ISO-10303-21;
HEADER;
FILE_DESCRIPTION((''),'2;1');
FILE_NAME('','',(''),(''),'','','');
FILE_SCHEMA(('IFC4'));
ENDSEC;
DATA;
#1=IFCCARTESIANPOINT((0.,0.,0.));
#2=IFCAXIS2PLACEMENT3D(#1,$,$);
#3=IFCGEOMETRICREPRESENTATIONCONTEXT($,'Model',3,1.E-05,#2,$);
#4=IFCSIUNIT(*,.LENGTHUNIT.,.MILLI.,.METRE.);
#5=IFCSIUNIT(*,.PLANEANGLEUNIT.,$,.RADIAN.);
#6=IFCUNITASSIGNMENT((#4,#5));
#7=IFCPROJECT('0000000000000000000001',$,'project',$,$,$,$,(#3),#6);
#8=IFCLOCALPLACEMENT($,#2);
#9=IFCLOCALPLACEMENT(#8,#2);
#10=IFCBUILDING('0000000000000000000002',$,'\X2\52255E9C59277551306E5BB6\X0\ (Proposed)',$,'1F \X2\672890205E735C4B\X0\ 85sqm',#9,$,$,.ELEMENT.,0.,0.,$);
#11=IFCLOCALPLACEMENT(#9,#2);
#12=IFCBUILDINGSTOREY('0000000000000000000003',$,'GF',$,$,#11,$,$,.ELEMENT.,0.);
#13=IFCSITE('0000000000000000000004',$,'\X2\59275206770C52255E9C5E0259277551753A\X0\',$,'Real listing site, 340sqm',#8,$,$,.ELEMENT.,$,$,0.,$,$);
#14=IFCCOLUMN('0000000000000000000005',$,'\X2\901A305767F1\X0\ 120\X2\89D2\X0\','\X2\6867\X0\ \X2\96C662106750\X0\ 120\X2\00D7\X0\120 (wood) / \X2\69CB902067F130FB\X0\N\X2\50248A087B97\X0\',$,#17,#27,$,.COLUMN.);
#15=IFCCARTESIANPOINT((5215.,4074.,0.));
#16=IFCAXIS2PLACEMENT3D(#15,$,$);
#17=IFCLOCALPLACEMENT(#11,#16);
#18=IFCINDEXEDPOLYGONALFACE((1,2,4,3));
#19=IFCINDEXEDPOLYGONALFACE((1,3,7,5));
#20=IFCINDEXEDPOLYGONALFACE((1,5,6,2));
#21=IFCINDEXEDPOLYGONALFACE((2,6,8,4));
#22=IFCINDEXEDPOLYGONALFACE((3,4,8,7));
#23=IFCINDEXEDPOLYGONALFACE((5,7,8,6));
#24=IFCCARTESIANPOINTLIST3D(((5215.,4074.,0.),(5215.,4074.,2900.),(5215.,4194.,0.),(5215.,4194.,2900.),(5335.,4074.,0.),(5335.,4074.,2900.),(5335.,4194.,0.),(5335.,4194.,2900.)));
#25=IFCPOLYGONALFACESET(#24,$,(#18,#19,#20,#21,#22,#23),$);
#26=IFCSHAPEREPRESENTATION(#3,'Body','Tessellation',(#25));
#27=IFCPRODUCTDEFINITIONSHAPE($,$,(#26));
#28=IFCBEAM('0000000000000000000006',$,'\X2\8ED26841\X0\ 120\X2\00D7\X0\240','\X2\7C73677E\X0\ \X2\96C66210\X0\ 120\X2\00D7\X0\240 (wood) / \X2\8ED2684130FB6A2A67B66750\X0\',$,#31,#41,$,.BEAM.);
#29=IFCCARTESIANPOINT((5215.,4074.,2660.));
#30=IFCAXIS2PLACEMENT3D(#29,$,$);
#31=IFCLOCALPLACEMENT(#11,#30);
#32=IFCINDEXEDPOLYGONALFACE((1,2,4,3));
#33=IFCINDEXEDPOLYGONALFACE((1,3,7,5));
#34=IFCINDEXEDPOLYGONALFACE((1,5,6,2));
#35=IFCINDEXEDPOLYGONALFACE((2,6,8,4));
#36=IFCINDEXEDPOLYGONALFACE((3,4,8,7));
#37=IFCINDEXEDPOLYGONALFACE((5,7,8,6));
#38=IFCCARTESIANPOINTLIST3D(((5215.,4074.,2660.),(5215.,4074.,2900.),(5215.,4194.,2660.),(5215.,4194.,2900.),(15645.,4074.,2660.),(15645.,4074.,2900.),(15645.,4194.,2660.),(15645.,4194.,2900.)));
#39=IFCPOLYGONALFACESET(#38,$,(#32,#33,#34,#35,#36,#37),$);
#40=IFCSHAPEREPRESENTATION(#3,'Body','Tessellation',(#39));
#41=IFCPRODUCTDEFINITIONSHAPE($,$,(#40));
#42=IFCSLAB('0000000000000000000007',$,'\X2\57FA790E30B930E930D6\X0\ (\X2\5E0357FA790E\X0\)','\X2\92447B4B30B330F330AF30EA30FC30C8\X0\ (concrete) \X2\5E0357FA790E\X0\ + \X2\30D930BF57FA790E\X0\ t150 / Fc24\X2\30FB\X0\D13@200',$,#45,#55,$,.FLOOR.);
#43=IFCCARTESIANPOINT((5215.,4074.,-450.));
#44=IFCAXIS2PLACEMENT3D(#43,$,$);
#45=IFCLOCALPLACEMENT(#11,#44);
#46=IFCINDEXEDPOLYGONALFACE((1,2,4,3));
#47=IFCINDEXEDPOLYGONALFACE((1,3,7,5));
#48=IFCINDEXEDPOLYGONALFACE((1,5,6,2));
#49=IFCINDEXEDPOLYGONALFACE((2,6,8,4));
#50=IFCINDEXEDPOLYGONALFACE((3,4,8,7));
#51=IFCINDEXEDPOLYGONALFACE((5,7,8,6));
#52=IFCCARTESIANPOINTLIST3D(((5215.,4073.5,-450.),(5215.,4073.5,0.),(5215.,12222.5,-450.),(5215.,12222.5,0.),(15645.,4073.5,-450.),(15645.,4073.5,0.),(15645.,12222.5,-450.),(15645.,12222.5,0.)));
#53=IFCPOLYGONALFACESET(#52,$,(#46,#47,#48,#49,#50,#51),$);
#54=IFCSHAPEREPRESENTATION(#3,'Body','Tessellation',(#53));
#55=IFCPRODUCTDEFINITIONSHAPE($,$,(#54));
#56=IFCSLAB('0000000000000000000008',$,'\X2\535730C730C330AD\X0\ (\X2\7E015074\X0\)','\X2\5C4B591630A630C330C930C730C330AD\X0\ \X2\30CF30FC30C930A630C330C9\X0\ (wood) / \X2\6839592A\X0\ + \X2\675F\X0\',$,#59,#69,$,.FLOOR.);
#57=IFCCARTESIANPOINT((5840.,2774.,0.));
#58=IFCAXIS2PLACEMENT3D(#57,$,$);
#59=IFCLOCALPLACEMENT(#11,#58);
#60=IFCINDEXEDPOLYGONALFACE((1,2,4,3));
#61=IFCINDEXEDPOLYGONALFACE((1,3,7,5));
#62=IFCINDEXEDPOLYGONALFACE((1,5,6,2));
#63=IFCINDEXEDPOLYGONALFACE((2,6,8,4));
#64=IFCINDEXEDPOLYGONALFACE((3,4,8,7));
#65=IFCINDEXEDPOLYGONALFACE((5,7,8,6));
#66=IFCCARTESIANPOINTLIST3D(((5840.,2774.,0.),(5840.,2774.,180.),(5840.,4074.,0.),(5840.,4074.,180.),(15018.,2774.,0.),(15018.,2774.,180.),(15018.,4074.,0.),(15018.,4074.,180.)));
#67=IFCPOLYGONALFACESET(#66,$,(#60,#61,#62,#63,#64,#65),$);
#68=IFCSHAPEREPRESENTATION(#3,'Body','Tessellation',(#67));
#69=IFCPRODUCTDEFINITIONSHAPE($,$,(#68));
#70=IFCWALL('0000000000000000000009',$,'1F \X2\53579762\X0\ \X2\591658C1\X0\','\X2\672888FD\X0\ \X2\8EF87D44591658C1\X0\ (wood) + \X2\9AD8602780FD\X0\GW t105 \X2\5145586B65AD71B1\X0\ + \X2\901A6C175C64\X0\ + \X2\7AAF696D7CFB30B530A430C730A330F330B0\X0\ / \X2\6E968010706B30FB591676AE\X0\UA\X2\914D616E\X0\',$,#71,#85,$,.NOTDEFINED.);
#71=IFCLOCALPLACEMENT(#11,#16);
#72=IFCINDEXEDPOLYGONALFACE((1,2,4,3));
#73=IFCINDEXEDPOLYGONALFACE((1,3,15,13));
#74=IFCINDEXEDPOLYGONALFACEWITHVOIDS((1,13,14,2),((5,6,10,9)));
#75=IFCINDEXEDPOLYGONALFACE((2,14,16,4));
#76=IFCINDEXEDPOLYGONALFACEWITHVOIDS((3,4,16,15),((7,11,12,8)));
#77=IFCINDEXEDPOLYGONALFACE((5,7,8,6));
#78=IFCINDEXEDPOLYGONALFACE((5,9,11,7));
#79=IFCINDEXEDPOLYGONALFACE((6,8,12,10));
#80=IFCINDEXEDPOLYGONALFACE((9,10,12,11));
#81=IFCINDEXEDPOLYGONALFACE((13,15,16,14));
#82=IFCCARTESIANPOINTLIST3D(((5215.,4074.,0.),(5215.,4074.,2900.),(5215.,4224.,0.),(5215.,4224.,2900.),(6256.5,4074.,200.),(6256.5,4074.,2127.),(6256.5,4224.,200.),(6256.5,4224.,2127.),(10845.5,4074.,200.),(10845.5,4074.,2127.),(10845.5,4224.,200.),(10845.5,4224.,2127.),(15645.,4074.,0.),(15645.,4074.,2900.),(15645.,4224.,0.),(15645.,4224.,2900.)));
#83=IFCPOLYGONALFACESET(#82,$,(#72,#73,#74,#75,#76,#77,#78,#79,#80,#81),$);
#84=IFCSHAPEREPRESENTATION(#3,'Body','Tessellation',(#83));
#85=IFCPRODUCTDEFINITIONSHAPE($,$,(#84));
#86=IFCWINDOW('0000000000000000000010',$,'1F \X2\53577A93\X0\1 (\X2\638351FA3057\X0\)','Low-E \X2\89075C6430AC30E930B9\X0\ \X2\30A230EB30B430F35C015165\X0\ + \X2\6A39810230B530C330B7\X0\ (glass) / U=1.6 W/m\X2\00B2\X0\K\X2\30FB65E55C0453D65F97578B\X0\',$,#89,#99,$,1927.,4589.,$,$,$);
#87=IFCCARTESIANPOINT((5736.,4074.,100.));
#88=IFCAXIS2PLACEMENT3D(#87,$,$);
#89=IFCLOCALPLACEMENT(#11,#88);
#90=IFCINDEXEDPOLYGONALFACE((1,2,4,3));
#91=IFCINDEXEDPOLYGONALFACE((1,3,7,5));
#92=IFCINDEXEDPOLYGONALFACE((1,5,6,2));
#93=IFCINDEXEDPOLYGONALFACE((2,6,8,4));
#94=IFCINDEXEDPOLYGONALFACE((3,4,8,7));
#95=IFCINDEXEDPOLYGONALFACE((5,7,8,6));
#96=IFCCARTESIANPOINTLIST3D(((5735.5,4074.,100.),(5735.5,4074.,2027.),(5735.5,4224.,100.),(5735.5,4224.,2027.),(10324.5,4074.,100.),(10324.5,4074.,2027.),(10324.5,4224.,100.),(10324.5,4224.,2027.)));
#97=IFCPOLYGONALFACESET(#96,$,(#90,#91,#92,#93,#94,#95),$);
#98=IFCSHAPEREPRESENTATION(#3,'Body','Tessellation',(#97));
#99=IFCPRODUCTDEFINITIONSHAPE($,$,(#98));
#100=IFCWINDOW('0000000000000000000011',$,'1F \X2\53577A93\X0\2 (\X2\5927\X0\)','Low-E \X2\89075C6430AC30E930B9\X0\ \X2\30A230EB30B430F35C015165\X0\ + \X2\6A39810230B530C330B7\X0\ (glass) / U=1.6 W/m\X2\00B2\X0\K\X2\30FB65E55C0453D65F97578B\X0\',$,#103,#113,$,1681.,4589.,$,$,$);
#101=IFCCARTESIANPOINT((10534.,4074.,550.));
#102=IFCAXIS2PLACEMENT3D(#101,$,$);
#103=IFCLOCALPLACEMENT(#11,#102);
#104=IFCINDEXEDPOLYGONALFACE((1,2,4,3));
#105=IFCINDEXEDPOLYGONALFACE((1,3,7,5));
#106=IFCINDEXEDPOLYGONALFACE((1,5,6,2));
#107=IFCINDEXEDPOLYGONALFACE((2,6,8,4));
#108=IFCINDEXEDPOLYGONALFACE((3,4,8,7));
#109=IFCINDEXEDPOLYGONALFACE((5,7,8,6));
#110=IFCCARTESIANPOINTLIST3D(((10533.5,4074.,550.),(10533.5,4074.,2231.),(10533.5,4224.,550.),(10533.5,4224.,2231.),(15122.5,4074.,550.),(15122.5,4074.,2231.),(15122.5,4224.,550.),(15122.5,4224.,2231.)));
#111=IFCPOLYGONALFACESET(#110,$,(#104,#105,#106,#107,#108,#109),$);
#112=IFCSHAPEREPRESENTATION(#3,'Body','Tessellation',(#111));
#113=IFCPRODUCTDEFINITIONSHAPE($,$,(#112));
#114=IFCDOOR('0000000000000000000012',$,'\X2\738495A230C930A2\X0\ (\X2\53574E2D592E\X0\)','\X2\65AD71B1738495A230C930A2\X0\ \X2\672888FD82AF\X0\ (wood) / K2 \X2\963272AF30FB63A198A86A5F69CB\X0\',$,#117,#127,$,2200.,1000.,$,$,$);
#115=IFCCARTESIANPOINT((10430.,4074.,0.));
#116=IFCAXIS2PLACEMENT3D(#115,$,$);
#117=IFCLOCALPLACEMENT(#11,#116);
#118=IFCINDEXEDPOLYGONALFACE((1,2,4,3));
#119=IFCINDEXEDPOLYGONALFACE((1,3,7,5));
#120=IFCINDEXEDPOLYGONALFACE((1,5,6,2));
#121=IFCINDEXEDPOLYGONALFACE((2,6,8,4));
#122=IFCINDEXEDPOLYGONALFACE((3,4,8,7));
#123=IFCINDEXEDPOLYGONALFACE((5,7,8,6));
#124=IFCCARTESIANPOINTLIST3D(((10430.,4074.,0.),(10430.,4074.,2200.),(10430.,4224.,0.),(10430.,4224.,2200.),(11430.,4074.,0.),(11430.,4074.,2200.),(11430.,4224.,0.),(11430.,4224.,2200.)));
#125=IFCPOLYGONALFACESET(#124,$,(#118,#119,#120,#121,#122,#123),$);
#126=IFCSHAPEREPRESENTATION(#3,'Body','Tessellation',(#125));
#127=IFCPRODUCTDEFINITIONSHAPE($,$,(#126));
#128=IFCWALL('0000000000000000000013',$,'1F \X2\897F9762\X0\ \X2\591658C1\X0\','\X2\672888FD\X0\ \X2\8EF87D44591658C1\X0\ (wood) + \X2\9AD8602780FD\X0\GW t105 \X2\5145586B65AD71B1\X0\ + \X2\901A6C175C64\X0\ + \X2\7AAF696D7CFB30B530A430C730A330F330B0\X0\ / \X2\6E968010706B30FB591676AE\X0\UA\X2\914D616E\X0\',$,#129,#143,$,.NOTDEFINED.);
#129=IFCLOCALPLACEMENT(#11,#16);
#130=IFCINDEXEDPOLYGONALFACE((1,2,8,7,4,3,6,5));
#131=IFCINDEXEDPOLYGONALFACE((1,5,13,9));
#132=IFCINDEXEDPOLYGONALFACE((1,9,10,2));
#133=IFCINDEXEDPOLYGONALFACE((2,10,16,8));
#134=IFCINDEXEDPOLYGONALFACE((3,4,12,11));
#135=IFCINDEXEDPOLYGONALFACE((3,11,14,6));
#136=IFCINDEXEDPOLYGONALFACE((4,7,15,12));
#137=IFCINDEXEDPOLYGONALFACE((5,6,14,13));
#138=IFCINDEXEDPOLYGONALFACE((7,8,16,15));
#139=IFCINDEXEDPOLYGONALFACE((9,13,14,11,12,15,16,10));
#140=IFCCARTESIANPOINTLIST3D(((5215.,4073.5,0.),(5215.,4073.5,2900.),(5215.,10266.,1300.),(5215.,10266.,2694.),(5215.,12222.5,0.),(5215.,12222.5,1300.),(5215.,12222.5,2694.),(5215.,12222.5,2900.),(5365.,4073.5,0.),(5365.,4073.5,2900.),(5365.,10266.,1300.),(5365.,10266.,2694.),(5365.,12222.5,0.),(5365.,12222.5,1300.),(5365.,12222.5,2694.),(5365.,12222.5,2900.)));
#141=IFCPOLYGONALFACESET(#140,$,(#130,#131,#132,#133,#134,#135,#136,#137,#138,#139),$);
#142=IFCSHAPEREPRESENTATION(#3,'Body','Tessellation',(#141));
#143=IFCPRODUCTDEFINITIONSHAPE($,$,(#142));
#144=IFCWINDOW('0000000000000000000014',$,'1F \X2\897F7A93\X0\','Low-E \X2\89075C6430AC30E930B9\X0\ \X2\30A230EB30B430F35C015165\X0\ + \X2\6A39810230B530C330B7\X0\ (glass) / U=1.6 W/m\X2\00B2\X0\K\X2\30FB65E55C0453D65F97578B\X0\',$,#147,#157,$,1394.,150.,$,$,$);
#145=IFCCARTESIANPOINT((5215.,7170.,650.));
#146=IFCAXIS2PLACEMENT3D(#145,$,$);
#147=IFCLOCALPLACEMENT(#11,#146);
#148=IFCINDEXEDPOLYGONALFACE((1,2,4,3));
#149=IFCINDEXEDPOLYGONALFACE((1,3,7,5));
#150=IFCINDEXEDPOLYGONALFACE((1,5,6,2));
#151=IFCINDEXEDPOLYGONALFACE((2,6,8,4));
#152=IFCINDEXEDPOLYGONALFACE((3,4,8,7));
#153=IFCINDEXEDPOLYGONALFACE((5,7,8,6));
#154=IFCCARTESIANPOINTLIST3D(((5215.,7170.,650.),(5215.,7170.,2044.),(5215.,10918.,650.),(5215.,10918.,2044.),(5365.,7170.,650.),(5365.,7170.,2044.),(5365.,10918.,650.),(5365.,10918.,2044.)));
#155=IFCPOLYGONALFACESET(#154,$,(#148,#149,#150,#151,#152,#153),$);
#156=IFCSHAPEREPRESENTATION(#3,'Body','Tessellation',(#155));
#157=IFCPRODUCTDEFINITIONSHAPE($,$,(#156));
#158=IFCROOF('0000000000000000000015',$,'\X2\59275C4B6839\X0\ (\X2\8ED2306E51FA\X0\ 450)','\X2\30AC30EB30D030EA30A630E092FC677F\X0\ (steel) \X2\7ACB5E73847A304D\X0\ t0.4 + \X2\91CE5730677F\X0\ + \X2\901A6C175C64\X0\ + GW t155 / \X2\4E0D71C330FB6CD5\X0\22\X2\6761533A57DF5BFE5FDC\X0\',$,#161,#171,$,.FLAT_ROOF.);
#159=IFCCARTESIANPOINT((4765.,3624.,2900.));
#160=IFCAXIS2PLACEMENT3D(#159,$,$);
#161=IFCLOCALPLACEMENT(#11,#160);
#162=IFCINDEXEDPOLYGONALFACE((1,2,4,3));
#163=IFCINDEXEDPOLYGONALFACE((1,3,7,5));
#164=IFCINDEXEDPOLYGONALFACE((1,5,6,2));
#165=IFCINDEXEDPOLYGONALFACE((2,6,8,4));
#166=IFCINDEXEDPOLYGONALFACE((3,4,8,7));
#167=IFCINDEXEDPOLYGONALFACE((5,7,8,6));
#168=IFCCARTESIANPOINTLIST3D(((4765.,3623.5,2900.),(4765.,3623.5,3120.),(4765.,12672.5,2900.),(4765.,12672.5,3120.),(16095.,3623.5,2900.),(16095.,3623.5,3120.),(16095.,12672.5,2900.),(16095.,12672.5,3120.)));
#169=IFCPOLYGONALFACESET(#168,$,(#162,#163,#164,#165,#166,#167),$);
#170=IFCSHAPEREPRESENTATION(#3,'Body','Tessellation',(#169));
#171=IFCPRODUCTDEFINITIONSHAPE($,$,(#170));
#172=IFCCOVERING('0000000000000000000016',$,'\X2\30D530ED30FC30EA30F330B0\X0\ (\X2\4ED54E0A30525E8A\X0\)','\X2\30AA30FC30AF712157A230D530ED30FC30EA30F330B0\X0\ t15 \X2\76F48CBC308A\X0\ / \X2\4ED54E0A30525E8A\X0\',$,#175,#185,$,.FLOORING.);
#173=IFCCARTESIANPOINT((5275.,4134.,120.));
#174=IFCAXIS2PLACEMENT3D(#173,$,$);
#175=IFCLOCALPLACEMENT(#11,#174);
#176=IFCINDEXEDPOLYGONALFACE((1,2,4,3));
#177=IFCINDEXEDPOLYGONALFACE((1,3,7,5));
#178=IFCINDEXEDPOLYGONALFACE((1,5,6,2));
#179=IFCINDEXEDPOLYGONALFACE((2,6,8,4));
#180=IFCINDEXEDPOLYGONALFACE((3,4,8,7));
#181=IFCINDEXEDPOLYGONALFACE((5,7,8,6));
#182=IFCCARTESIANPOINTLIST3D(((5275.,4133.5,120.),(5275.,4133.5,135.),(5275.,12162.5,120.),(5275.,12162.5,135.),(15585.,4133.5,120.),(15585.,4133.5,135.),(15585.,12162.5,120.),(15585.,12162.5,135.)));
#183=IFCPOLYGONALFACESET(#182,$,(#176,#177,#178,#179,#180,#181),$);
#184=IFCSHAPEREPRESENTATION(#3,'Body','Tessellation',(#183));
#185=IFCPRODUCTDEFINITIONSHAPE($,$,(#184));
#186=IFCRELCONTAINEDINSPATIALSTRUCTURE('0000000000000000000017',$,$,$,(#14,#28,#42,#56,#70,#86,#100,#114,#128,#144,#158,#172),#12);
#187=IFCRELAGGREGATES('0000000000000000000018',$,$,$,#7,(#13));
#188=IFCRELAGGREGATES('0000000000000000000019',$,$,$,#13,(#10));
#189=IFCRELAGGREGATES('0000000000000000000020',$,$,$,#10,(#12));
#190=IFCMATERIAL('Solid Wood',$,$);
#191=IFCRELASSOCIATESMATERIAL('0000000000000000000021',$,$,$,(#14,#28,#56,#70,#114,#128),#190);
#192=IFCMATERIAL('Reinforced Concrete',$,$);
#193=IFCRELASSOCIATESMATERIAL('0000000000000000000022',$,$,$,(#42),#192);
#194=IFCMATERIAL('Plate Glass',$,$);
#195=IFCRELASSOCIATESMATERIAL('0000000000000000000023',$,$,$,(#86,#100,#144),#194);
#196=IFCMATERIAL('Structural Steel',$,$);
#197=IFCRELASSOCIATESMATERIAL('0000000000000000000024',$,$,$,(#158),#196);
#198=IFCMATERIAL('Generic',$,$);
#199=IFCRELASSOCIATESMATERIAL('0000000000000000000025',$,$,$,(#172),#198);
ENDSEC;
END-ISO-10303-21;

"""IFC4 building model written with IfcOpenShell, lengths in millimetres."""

from ifc_helpers import new_model, si_unit, frame, frame_2d, origin, place, context, project, spatial, rectangle, extrude, material, element, fill, save


model = new_model("IFC4")

# Units and contexts
model_context = context("Model", 3, precision=1e-05, world=origin())
ifc_project = project(units=[si_unit("LENGTHUNIT", "METRE", prefix="MILLI"), si_unit("PLANEANGLEUNIT", "RADIAN")], contexts=[model_context])

# Site, building, storey
site_placement = place(None, origin())
site = spatial("IfcSite", under=ifc_project, at=site_placement, Name="大分県別府市大畑町", ObjectType="Real listing site, 340sqm", CompositionType="ELEMENT", RefElevation=0.0)
building_placement = place(site_placement, origin())
building = spatial("IfcBuilding", under=site, at=building_placement, Name="別府大畑の家 (Proposed)", ObjectType="1F 木造平屋 85sqm", CompositionType="ELEMENT", ElevationOfRefHeight=0.0, ElevationOfTerrain=0.0)
storey_placement = place(building_placement, origin())
storey = spatial("IfcBuildingStorey", under=building, at=storey_placement, Name="GF", CompositionType="ELEMENT", Elevation=0.0)

# Column
ifc_material_1 = material(Name="Solid Wood")
column_1_placement = place(storey_placement, frame((5215.0, 4074.0, 0.0)))
element("IfcColumn", 1, at=column_1_placement, inside=storey, material=ifc_material_1, Name="通し柱 120角", Description="桧 集成材 120×120 (wood) / 構造柱・N値計算", PredefinedType="COLUMN", context=model_context, shape_type="SweptSolid", body=[
    extrude(rectangle(XDim=120.0, YDim=120.0, at=frame_2d((60.0, 60.0))), frame((5215.0, 4074.0, 0.0)), (0.0, 0.0, 1.0), 2900.0),
])

# Beam
beam_1_placement = place(storey_placement, frame((5215.0, 4074.0, 2660.0)))
element("IfcBeam", 2, at=beam_1_placement, inside=storey, material=ifc_material_1, Name="軒桁 120×240", Description="米松 集成 120×240 (wood) / 軒桁・横架材", PredefinedType="BEAM", context=model_context, shape_type="SweptSolid", body=[
    extrude(rectangle(XDim=10430.0, YDim=120.0, at=frame_2d((5215.0, 60.0))), frame((5215.0, 4074.0, 2660.0)), (0.0, 0.0, 1.0), 240.0),
])

# Slabs
ifc_material_2 = material(Name="Reinforced Concrete")
slab_1_placement = place(storey_placement, frame((5215.0, 4074.0, -450.0)))
element("IfcSlab", 3, at=slab_1_placement, inside=storey, material=ifc_material_2, Name="基礎スラブ (布基礎)", Description="鉄筋コンクリート (concrete) 布基礎 + ベタ基礎 t150 / Fc24・D13@200", PredefinedType="FLOOR", context=model_context, shape_type="SweptSolid", body=[
    extrude(rectangle(XDim=10430.0, YDim=8149.0, at=frame_2d((5215.0, 4074.0))), frame((5215.0, 4074.0, -450.0)), (0.0, 0.0, 1.0), 450.0),
])
slab_2_placement = place(storey_placement, frame((5840.0, 2774.0, 0.0)))
element("IfcSlab", 4, at=slab_2_placement, inside=storey, material=ifc_material_1, Name="南デッキ (縁側)", Description="屋外ウッドデッキ ハードウッド (wood) / 根太 + 束", PredefinedType="FLOOR", context=model_context, shape_type="SweptSolid", body=[
    extrude(rectangle(XDim=9178.0, YDim=1300.0, at=frame_2d((4589.0, 650.0))), frame((5840.0, 2774.0, 0.0)), (0.0, 0.0, 1.0), 180.0),
])

# Wall, openings, windows, door
wall_1_placement = place(storey_placement, frame((5215.0, 4074.0, 0.0)))
wall_1 = element("IfcWall", 5, at=wall_1_placement, inside=storey, material=ifc_material_1, Name="1F 南面 外壁", Description="木製 軸組外壁 (wood) + 高性能GW t105 充填断熱 + 通気層 + 窯業系サイディング / 準耐火・外皮UA配慮", PredefinedType="NOTDEFINED", context=model_context, shape_type="SweptSolid", body=[
    extrude(rectangle(XDim=10430.0, YDim=150.0, at=frame_2d((5215.0, 75.0))), frame((5215.0, 4074.0, 0.0)), (0.0, 0.0, 1.0), 2900.0),
])
opening_1_placement = place(storey_placement, frame((5736.0, 4074.0, 100.0)))
opening_1 = element("IfcOpeningElement", 6, at=opening_1_placement, cuts=wall_1, PredefinedType="NOTDEFINED", context=model_context, shape_type="SweptSolid", body=[
    extrude(rectangle(XDim=4589.0, YDim=150.0, at=frame_2d((2294.0, 75.0))), frame((5736.0, 4074.0, 100.0)), (0.0, 0.0, 1.0), 1927.0),
])
opening_2_placement = place(storey_placement, frame((10534.0, 4074.0, 550.0)))
opening_2 = element("IfcOpeningElement", 7, at=opening_2_placement, cuts=wall_1, PredefinedType="NOTDEFINED", context=model_context, shape_type="SweptSolid", body=[
    extrude(rectangle(XDim=4589.0, YDim=150.0, at=frame_2d((2294.0, 75.0))), frame((10534.0, 4074.0, 550.0)), (0.0, 0.0, 1.0), 1681.0),
])
opening_3_placement = place(storey_placement, frame((10430.0, 4074.0, 0.0)))
opening_3 = element("IfcOpeningElement", 8, at=opening_3_placement, cuts=wall_1, PredefinedType="NOTDEFINED", context=model_context, shape_type="SweptSolid", body=[
    extrude(rectangle(XDim=1000.0, YDim=150.0, at=frame_2d((500.0, 75.0))), frame((10430.0, 4074.0, 0.0)), (0.0, 0.0, 1.0), 2200.0),
])
ifc_material_3 = material(Name="Plate Glass")
window_1_placement = place(storey_placement, frame((5736.0, 4074.0, 100.0)))
window_1 = element("IfcWindow", 9, at=window_1_placement, inside=storey, material=ifc_material_3, Name="1F 南窓1 (掃出し)", Description="Low-E 複層ガラス アルゴン封入 + 樹脂サッシ (glass) / U=1.6 W/m²K・日射取得型", OverallHeight=1927.0, OverallWidth=4589.0, context=model_context, shape_type="SweptSolid", body=[
    extrude(rectangle(XDim=4589.0, YDim=150.0, at=frame_2d((2294.0, 75.0))), frame((5736.0, 4074.0, 100.0)), (0.0, 0.0, 1.0), 1927.0),
])
fill(opening_1, window_1)
window_2_placement = place(storey_placement, frame((10534.0, 4074.0, 550.0)))
window_2 = element("IfcWindow", 10, at=window_2_placement, inside=storey, material=ifc_material_3, Name="1F 南窓2 (大)", Description="Low-E 複層ガラス アルゴン封入 + 樹脂サッシ (glass) / U=1.6 W/m²K・日射取得型", OverallHeight=1681.0, OverallWidth=4589.0, context=model_context, shape_type="SweptSolid", body=[
    extrude(rectangle(XDim=4589.0, YDim=150.0, at=frame_2d((2294.0, 75.0))), frame((10534.0, 4074.0, 550.0)), (0.0, 0.0, 1.0), 1681.0),
])
fill(opening_2, window_2)
door_placement = place(storey_placement, frame((10430.0, 4074.0, 0.0)))
door = element("IfcDoor", 11, at=door_placement, inside=storey, material=ifc_material_1, Name="玄関ドア (南中央)", Description="断熱玄関ドア 木製芯 (wood) / K2 防犯・採風機構", OverallHeight=2200.0, OverallWidth=1000.0, context=model_context, shape_type="SweptSolid", body=[
    extrude(rectangle(XDim=1000.0, YDim=150.0, at=frame_2d((500.0, 75.0))), frame((10430.0, 4074.0, 0.0)), (0.0, 0.0, 1.0), 2200.0),
])
fill(opening_3, door)

# Wall, opening, window
wall_2_placement = place(storey_placement, frame((5215.0, 4074.0, 0.0)))
wall_2 = element("IfcWall", 12, at=wall_2_placement, inside=storey, material=ifc_material_1, Name="1F 西面 外壁", Description="木製 軸組外壁 (wood) + 高性能GW t105 充填断熱 + 通気層 + 窯業系サイディング / 準耐火・外皮UA配慮", PredefinedType="NOTDEFINED", context=model_context, shape_type="SweptSolid", body=[
    extrude(rectangle(XDim=150.0, YDim=8149.0, at=frame_2d((75.0, 4074.0))), frame((5215.0, 4074.0, 0.0)), (0.0, 0.0, 1.0), 2900.0),
])
opening_4_placement = place(storey_placement, frame((5215.0, 7170.0, 650.0)))
opening_4 = element("IfcOpeningElement", 13, at=opening_4_placement, cuts=wall_2, PredefinedType="NOTDEFINED", context=model_context, shape_type="SweptSolid", body=[
    extrude(rectangle(XDim=150.0, YDim=3748.0, at=frame_2d((75.0, 1874.0))), frame((5215.0, 7170.0, 650.0)), (0.0, 0.0, 1.0), 1394.0),
])
window_3_placement = place(storey_placement, frame((5215.0, 7170.0, 650.0)))
window_3 = element("IfcWindow", 14, at=window_3_placement, inside=storey, material=ifc_material_3, Name="1F 西窓", Description="Low-E 複層ガラス アルゴン封入 + 樹脂サッシ (glass) / U=1.6 W/m²K・日射取得型", OverallHeight=1394.0, OverallWidth=150.0, context=model_context, shape_type="SweptSolid", body=[
    extrude(rectangle(XDim=150.0, YDim=3748.0, at=frame_2d((75.0, 1874.0))), frame((5215.0, 7170.0, 650.0)), (0.0, 0.0, 1.0), 1394.0),
])
fill(opening_4, window_3)

# Roof
ifc_material_4 = material(Name="Structural Steel")
roof_placement = place(storey_placement, frame((4765.0, 3624.0, 2900.0)))
element("IfcRoof", 15, at=roof_placement, inside=storey, material=ifc_material_4, Name="大屋根 (軒の出 450)", Description="ガルバリウム鋼板 (steel) 立平葺き t0.4 + 野地板 + 通気層 + GW t155 / 不燃・法22条区域対応", PredefinedType="FLAT_ROOF", context=model_context, shape_type="SweptSolid", body=[
    extrude(rectangle(XDim=11330.0, YDim=9049.0, at=frame_2d((5665.0, 4524.0))), frame((4765.0, 3624.0, 2900.0)), (0.0, 0.0, 1.0), 220.0),
])

# Covering
ifc_material_5 = material(Name="Generic")
covering_1_placement = place(storey_placement, frame((5275.0, 4134.0, 120.0)))
element("IfcCovering", 16, at=covering_1_placement, inside=storey, material=ifc_material_5, Name="フローリング (仕上げ床)", Description="オーク無垢フローリング t15 直貼り / 仕上げ床", PredefinedType="FLOORING", context=model_context, shape_type="SweptSolid", body=[
    extrude(rectangle(XDim=10310.0, YDim=8029.0, at=frame_2d((5155.0, 4014.0))), frame((5275.0, 4134.0, 120.0)), (0.0, 0.0, 1.0), 15.0),
])

save(model, "model.ifc")
